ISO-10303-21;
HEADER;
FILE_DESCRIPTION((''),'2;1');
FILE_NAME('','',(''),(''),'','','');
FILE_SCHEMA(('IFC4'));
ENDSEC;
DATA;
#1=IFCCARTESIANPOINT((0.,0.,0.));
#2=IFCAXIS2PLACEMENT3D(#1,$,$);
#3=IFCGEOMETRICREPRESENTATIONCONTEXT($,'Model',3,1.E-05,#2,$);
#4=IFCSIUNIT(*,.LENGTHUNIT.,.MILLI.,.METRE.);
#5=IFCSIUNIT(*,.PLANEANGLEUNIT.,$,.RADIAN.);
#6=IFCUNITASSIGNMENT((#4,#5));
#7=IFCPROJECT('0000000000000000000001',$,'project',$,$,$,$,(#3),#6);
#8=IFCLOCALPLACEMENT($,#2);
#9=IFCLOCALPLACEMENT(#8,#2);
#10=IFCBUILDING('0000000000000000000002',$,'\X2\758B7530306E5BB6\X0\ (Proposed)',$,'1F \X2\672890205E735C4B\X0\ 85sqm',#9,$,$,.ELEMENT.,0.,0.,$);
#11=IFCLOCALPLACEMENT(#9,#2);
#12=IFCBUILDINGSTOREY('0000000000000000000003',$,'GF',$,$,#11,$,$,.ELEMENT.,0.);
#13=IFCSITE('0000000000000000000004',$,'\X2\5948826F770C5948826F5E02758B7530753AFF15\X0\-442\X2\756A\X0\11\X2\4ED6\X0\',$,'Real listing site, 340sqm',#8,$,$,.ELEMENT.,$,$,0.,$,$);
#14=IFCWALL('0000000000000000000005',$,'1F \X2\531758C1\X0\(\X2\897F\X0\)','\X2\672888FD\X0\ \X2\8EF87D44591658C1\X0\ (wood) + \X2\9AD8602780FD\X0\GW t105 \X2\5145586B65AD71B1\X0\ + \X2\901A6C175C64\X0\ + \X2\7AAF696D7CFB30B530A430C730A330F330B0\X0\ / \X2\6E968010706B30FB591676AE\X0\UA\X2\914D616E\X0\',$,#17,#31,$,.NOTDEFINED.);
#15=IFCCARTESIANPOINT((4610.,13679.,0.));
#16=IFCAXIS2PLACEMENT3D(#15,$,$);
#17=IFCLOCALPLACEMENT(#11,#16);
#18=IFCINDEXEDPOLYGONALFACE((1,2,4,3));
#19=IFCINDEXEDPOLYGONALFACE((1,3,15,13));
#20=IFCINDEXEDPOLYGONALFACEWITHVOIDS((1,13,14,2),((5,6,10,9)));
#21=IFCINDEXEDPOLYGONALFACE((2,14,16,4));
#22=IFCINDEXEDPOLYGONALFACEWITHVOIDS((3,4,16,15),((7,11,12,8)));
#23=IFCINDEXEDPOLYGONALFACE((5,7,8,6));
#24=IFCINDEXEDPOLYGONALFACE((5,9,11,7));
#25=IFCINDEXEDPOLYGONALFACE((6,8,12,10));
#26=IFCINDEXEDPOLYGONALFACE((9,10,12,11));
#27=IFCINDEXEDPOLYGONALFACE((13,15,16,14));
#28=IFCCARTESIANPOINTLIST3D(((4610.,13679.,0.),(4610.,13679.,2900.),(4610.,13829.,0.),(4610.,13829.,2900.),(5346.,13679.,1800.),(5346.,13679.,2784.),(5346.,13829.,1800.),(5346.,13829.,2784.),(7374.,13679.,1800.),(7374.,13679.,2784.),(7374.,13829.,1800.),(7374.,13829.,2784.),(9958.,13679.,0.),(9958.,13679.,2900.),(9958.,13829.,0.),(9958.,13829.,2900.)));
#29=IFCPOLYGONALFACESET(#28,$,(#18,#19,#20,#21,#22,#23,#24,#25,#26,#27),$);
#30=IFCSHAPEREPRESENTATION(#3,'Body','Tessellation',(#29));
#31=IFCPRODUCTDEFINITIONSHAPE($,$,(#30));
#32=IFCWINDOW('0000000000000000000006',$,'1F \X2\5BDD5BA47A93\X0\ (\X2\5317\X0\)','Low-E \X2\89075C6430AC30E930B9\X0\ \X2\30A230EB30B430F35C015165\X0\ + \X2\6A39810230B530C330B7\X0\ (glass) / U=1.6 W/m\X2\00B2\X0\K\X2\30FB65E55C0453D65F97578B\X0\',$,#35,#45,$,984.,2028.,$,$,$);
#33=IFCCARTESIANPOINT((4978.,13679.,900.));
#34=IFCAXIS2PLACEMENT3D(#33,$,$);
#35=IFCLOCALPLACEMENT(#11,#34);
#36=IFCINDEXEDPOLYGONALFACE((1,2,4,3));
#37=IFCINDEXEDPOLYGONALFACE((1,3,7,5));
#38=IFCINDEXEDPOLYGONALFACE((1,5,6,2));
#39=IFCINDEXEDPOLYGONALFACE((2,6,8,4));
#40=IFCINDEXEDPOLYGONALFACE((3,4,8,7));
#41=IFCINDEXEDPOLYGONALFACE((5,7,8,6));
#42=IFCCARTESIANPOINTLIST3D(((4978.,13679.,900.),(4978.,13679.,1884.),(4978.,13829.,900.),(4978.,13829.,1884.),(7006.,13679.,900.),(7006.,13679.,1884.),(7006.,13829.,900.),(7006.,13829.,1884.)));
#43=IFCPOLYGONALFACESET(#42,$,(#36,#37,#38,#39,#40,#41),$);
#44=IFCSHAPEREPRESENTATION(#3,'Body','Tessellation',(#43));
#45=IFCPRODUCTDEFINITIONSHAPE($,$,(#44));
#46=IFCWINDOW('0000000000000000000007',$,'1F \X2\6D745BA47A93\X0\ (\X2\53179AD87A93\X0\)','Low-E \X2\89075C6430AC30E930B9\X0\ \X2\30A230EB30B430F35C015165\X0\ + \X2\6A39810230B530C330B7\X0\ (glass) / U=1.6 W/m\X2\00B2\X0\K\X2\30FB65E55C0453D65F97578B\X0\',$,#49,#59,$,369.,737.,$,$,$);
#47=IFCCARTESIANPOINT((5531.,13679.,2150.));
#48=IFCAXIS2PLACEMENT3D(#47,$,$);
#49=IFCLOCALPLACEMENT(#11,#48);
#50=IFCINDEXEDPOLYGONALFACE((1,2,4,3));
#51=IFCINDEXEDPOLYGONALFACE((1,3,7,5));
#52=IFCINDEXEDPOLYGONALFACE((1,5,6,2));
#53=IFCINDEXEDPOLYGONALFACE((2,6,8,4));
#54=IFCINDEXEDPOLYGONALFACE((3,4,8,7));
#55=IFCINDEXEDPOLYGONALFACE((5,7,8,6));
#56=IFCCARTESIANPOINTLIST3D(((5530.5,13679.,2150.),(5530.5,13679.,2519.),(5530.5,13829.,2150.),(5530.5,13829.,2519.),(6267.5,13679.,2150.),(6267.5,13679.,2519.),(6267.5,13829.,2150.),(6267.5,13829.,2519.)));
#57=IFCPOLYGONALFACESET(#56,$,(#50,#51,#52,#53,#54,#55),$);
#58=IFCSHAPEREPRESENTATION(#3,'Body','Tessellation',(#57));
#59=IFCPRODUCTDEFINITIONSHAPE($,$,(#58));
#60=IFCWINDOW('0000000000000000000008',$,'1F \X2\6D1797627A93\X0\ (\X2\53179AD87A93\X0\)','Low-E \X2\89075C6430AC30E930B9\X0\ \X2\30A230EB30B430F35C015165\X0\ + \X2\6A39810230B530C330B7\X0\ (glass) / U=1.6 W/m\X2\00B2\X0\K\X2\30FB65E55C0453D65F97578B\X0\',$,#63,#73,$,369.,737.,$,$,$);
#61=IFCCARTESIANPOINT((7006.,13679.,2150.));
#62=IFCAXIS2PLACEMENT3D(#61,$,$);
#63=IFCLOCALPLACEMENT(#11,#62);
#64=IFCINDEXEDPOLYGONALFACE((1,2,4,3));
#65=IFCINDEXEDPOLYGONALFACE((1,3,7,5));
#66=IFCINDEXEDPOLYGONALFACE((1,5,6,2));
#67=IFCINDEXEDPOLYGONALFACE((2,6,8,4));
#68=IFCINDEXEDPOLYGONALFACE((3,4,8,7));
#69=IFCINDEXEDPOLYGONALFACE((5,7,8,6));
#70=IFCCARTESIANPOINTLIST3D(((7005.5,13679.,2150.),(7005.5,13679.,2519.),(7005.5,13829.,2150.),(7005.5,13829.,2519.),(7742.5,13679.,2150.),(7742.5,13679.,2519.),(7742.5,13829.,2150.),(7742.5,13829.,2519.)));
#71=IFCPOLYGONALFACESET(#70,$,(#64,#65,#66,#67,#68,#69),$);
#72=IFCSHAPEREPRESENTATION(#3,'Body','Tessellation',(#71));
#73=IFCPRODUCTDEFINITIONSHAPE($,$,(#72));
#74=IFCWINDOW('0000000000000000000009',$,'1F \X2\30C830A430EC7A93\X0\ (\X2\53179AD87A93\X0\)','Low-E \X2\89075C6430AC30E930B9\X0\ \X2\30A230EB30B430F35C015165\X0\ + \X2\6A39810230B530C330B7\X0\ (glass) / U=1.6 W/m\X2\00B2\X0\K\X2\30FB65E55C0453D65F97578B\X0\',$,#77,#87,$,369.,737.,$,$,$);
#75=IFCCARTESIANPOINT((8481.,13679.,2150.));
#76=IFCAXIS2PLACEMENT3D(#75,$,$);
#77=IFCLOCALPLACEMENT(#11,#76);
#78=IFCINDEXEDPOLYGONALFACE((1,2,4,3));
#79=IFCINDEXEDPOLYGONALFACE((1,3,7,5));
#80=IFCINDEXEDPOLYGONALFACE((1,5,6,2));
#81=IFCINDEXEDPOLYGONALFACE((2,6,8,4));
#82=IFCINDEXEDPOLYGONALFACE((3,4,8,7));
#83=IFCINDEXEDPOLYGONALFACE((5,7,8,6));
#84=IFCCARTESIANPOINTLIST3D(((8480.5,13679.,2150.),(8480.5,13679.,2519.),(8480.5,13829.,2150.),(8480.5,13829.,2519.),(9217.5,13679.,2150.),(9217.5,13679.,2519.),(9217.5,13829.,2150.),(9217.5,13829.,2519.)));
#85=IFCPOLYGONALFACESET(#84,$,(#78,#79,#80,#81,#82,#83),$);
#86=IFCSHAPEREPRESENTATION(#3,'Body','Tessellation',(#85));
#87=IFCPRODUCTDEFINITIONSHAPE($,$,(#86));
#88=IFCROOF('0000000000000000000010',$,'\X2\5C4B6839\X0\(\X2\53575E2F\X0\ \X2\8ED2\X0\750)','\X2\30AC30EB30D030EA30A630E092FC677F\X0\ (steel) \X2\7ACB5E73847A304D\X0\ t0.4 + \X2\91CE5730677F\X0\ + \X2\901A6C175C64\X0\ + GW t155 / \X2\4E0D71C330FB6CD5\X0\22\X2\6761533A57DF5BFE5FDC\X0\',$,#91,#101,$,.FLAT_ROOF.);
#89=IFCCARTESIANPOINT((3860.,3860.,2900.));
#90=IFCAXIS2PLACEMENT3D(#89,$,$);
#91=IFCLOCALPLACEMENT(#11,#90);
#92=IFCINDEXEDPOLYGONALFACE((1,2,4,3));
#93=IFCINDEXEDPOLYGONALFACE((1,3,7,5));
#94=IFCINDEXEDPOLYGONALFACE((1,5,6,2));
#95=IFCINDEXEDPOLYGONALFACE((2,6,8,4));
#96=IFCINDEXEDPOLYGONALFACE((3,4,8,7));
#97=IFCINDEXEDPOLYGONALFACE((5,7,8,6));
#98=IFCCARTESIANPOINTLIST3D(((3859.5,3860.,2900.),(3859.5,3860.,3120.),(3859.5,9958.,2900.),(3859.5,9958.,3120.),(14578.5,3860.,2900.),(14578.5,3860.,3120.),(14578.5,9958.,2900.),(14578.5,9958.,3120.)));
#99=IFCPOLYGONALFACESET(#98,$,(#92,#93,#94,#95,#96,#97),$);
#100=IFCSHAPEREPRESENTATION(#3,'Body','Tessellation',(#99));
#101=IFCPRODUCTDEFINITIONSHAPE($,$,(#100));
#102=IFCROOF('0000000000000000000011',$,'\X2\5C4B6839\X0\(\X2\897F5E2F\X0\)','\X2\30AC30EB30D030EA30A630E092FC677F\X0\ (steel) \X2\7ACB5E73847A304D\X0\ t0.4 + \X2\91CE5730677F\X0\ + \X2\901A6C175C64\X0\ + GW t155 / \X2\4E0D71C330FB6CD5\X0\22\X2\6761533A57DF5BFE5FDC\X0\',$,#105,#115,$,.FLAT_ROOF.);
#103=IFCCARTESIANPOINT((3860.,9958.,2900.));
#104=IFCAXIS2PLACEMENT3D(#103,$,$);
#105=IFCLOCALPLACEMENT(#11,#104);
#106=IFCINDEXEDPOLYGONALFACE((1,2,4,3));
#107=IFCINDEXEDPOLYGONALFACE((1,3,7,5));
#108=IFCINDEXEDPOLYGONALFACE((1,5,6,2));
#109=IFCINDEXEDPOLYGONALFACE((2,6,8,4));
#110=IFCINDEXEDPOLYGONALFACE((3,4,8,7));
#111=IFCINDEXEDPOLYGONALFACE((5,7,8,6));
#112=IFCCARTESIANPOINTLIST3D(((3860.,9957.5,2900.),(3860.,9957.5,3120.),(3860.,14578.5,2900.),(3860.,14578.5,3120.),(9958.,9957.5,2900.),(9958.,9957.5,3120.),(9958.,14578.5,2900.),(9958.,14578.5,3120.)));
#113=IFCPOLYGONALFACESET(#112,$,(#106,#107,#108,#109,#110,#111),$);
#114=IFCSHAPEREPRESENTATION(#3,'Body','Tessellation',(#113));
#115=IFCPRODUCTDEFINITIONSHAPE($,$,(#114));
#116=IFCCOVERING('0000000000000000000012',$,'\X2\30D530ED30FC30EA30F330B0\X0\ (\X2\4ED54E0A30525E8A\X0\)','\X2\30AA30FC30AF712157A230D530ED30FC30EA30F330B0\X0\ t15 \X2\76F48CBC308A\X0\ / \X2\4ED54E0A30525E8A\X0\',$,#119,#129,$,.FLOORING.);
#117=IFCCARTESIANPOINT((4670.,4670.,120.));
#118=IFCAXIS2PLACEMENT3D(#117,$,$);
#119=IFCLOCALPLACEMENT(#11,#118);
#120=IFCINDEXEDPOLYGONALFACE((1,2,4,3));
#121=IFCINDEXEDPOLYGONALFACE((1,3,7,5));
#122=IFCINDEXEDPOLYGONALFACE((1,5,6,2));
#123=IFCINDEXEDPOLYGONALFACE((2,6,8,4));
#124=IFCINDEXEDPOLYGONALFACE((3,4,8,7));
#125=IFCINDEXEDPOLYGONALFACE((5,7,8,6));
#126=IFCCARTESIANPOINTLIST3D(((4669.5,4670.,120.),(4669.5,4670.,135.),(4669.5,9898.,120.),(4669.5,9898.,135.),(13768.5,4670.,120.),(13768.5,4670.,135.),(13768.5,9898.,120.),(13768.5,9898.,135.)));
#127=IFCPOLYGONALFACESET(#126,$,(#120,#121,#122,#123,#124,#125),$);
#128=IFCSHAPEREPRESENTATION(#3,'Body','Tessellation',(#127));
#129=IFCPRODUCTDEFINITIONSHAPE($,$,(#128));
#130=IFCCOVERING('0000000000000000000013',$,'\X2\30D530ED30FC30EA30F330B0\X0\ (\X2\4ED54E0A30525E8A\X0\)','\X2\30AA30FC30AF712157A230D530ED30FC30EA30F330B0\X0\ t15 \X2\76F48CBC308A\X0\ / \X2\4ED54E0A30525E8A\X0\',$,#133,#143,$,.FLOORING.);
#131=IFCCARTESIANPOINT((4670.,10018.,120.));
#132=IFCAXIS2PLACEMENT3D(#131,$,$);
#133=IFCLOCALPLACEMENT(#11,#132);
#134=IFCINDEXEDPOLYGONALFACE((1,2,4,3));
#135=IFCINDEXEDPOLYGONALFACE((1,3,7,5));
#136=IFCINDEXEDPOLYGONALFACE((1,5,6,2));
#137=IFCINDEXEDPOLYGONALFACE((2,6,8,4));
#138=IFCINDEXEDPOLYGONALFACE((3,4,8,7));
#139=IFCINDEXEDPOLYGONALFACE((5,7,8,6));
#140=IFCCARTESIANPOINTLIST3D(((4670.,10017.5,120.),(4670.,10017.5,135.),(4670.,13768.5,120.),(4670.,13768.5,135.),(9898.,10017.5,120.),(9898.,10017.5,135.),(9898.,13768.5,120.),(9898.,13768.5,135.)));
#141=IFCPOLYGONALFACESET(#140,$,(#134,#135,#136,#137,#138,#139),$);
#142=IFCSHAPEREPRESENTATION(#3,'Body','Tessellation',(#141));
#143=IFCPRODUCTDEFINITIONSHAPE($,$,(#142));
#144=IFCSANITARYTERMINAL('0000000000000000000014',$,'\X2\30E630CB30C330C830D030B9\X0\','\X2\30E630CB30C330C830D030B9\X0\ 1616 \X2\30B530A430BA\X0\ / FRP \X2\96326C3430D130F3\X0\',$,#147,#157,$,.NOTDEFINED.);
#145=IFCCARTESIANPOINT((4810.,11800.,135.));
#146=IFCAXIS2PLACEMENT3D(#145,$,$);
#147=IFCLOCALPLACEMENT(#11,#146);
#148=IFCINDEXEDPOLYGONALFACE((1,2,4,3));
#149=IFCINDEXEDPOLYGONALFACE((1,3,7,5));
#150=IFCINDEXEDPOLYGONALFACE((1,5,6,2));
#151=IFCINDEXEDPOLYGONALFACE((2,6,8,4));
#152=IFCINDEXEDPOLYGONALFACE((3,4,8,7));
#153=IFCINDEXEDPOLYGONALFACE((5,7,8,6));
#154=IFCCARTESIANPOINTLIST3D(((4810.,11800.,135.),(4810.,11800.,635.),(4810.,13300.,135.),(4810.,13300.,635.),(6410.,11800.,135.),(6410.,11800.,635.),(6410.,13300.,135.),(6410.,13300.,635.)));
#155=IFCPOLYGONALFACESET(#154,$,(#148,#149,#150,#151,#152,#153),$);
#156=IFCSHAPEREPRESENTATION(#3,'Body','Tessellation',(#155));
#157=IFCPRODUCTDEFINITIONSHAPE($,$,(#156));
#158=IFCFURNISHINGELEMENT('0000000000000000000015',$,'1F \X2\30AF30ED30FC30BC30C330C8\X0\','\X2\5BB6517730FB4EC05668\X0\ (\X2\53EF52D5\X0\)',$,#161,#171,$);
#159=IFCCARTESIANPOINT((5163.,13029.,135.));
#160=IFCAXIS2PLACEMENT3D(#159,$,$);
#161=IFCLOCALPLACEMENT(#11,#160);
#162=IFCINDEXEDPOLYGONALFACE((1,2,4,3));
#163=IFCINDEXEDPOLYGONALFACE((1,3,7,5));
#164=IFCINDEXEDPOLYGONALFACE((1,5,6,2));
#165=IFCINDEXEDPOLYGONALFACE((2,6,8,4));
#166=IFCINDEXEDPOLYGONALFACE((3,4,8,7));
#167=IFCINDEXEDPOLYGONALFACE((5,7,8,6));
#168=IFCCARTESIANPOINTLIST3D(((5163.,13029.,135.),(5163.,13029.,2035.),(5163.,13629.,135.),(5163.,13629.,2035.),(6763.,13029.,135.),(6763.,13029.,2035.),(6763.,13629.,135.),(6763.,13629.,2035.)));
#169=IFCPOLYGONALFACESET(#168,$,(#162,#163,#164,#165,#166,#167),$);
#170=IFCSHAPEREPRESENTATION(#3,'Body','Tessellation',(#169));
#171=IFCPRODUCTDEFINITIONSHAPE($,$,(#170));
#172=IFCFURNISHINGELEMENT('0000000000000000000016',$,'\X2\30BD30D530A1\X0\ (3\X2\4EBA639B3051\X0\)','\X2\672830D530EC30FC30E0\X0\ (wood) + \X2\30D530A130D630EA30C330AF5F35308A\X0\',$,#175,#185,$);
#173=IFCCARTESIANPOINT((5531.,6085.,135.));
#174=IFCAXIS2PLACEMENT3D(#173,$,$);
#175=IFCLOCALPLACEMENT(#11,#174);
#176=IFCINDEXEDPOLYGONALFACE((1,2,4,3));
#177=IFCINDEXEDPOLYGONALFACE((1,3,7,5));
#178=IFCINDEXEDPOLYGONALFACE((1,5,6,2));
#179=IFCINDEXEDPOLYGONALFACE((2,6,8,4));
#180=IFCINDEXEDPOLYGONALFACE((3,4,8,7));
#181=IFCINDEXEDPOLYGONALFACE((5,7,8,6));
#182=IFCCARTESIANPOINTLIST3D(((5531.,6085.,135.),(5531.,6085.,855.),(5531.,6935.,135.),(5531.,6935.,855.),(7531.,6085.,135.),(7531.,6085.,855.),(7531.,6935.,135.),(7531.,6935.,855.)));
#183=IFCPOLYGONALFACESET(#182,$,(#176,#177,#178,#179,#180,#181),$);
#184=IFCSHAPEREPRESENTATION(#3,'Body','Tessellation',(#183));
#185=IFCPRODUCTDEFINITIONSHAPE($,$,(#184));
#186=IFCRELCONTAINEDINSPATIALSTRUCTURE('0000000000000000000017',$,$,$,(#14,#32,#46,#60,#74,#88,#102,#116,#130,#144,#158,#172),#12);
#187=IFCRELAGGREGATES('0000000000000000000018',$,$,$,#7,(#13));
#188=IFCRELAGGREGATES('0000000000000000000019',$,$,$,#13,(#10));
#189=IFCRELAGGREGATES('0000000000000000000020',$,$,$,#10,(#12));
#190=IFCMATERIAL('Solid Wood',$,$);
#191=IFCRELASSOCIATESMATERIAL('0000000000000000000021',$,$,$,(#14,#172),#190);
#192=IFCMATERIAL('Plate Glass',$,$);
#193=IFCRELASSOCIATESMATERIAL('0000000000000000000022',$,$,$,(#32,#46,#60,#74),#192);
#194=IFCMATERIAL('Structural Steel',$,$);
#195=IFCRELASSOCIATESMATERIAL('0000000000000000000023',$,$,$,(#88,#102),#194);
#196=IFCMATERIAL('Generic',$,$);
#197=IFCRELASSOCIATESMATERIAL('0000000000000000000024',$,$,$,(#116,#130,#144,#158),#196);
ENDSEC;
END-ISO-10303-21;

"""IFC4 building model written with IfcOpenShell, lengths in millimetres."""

from ifc_helpers import new_model, si_unit, frame, frame_2d, origin, place, context, project, spatial, rectangle, extrude, material, element, fill, save


model = new_model("IFC4")

# Units and contexts
model_context = context("Model", 3, precision=1e-05, world=origin())
ifc_project = project(units=[si_unit("LENGTHUNIT", "METRE", prefix="MILLI"), si_unit("PLANEANGLEUNIT", "RADIAN")], contexts=[model_context])

# Site, building, storey
site_placement = place(None, origin())
site = spatial("IfcSite", under=ifc_project, at=site_placement, Name="奈良県奈良市疋田町５-442番11他", ObjectType="Real listing site, 340sqm", CompositionType="ELEMENT", RefElevation=0.0)
building_placement = place(site_placement, origin())
building = spatial("IfcBuilding", under=site, at=building_placement, Name="疋田の家 (Proposed)", ObjectType="1F 木造平屋 85sqm", CompositionType="ELEMENT", ElevationOfRefHeight=0.0, ElevationOfTerrain=0.0)
storey_placement = place(building_placement, origin())
storey = spatial("IfcBuildingStorey", under=building, at=storey_placement, Name="GF", CompositionType="ELEMENT", Elevation=0.0)

# Shared definitions
ifc_material_1 = material(Name="Solid Wood")

# Shared definitions
ifc_material_2 = material(Name="Plate Glass")

# Wall, openings, windows
wall_1_placement = place(storey_placement, frame((4610.0, 13679.0, 0.0)))
wall_1 = element("IfcWall", 1, at=wall_1_placement, inside=storey, material=ifc_material_1, Name="1F 北壁(西)", Description="木製 軸組外壁 (wood) + 高性能GW t105 充填断熱 + 通気層 + 窯業系サイディング / 準耐火・外皮UA配慮", PredefinedType="NOTDEFINED", context=model_context, shape_type="SweptSolid", body=[
    extrude(rectangle(XDim=5348.0, YDim=150.0, at=frame_2d((2674.0, 75.0))), frame((4610.0, 13679.0, 0.0)), (0.0, 0.0, 1.0), 2900.0),
])
opening_1_placement = place(storey_placement, frame((4978.0, 13679.0, 900.0)))
opening_1 = element("IfcOpeningElement", 2, at=opening_1_placement, cuts=wall_1, PredefinedType="NOTDEFINED", context=model_context, shape_type="SweptSolid", body=[
    extrude(rectangle(XDim=2028.0, YDim=150.0, at=frame_2d((1014.0, 75.0))), frame((4978.0, 13679.0, 900.0)), (0.0, 0.0, 1.0), 984.0),
])
opening_2_placement = place(storey_placement, frame((5531.0, 13679.0, 2150.0)))
opening_2 = element("IfcOpeningElement", 3, at=opening_2_placement, cuts=wall_1, PredefinedType="NOTDEFINED", context=model_context, shape_type="SweptSolid", body=[
    extrude(rectangle(XDim=737.0, YDim=150.0, at=frame_2d((368.0, 75.0))), frame((5531.0, 13679.0, 2150.0)), (0.0, 0.0, 1.0), 369.0),
])
opening_3_placement = place(storey_placement, frame((7006.0, 13679.0, 2150.0)))
opening_3 = element("IfcOpeningElement", 4, at=opening_3_placement, cuts=wall_1, PredefinedType="NOTDEFINED", context=model_context, shape_type="SweptSolid", body=[
    extrude(rectangle(XDim=737.0, YDim=150.0, at=frame_2d((368.0, 75.0))), frame((7006.0, 13679.0, 2150.0)), (0.0, 0.0, 1.0), 369.0),
])
opening_4_placement = place(storey_placement, frame((8481.0, 13679.0, 2150.0)))
opening_4 = element("IfcOpeningElement", 5, at=opening_4_placement, cuts=wall_1, PredefinedType="NOTDEFINED", context=model_context, shape_type="SweptSolid", body=[
    extrude(rectangle(XDim=737.0, YDim=150.0, at=frame_2d((368.0, 75.0))), frame((8481.0, 13679.0, 2150.0)), (0.0, 0.0, 1.0), 369.0),
])
window_1_placement = place(storey_placement, frame((4978.0, 13679.0, 900.0)))
window_1 = element("IfcWindow", 6, at=window_1_placement, inside=storey, material=ifc_material_2, Name="1F 寝室窓 (北)", Description="Low-E 複層ガラス アルゴン封入 + 樹脂サッシ (glass) / U=1.6 W/m²K・日射取得型", OverallHeight=984.0, OverallWidth=2028.0, context=model_context, shape_type="SweptSolid", body=[
    extrude(rectangle(XDim=2028.0, YDim=150.0, at=frame_2d((1014.0, 75.0))), frame((4978.0, 13679.0, 900.0)), (0.0, 0.0, 1.0), 984.0),
])
fill(opening_1, window_1)
window_2_placement = place(storey_placement, frame((5531.0, 13679.0, 2150.0)))
window_2 = element("IfcWindow", 7, at=window_2_placement, inside=storey, material=ifc_material_2, Name="1F 浴室窓 (北高窓)", Description="Low-E 複層ガラス アルゴン封入 + 樹脂サッシ (glass) / U=1.6 W/m²K・日射取得型", OverallHeight=369.0, OverallWidth=737.0, context=model_context, shape_type="SweptSolid", body=[
    extrude(rectangle(XDim=737.0, YDim=150.0, at=frame_2d((368.0, 75.0))), frame((5531.0, 13679.0, 2150.0)), (0.0, 0.0, 1.0), 369.0),
])
fill(opening_2, window_2)
window_3_placement = place(storey_placement, frame((7006.0, 13679.0, 2150.0)))
window_3 = element("IfcWindow", 8, at=window_3_placement, inside=storey, material=ifc_material_2, Name="1F 洗面窓 (北高窓)", Description="Low-E 複層ガラス アルゴン封入 + 樹脂サッシ (glass) / U=1.6 W/m²K・日射取得型", OverallHeight=369.0, OverallWidth=737.0, context=model_context, shape_type="SweptSolid", body=[
    extrude(rectangle(XDim=737.0, YDim=150.0, at=frame_2d((368.0, 75.0))), frame((7006.0, 13679.0, 2150.0)), (0.0, 0.0, 1.0), 369.0),
])
fill(opening_3, window_3)
window_4_placement = place(storey_placement, frame((8481.0, 13679.0, 2150.0)))
window_4 = element("IfcWindow", 9, at=window_4_placement, inside=storey, material=ifc_material_2, Name="1F トイレ窓 (北高窓)", Description="Low-E 複層ガラス アルゴン封入 + 樹脂サッシ (glass) / U=1.6 W/m²K・日射取得型", OverallHeight=369.0, OverallWidth=737.0, context=model_context, shape_type="SweptSolid", body=[
    extrude(rectangle(XDim=737.0, YDim=150.0, at=frame_2d((368.0, 75.0))), frame((8481.0, 13679.0, 2150.0)), (0.0, 0.0, 1.0), 369.0),
])
fill(opening_4, window_4)

# Roofs
ifc_material_3 = material(Name="Structural Steel")
roof_1_placement = place(storey_placement, frame((3860.0, 3860.0, 2900.0)))
element("IfcRoof", 10, at=roof_1_placement, inside=storey, material=ifc_material_3, Name="屋根(南帯 軒750)", Description="ガルバリウム鋼板 (steel) 立平葺き t0.4 + 野地板 + 通気層 + GW t155 / 不燃・法22条区域対応", PredefinedType="FLAT_ROOF", context=model_context, shape_type="SweptSolid", body=[
    extrude(rectangle(XDim=10719.0, YDim=6098.0, at=frame_2d((5359.0, 3049.0))), frame((3860.0, 3860.0, 2900.0)), (0.0, 0.0, 1.0), 220.0),
])
roof_2_placement = place(storey_placement, frame((3860.0, 9958.0, 2900.0)))
element("IfcRoof", 11, at=roof_2_placement, inside=storey, material=ifc_material_3, Name="屋根(西帯)", Description="ガルバリウム鋼板 (steel) 立平葺き t0.4 + 野地板 + 通気層 + GW t155 / 不燃・法22条区域対応", PredefinedType="FLAT_ROOF", context=model_context, shape_type="SweptSolid", body=[
    extrude(rectangle(XDim=6098.0, YDim=4621.0, at=frame_2d((3049.0, 2310.0))), frame((3860.0, 9958.0, 2900.0)), (0.0, 0.0, 1.0), 220.0),
])

# Coverings
ifc_material_4 = material(Name="Generic")
covering_1_placement = place(storey_placement, frame((4670.0, 4670.0, 120.0)))
element("IfcCovering", 12, at=covering_1_placement, inside=storey, material=ifc_material_4, Name="フローリング (仕上げ床)", Description="オーク無垢フローリング t15 直貼り / 仕上げ床", PredefinedType="FLOORING", context=model_context, shape_type="SweptSolid", body=[
    extrude(rectangle(XDim=9099.0, YDim=5228.0, at=frame_2d((4549.0, 2614.0))), frame((4670.0, 4670.0, 120.0)), (0.0, 0.0, 1.0), 15.0),
])
covering_2_placement = place(storey_placement, frame((4670.0, 10018.0, 120.0)))
element("IfcCovering", 13, at=covering_2_placement, inside=storey, material=ifc_material_4, Name="フローリング (仕上げ床)", Description="オーク無垢フローリング t15 直貼り / 仕上げ床", PredefinedType="FLOORING", context=model_context, shape_type="SweptSolid", body=[
    extrude(rectangle(XDim=5228.0, YDim=3751.0, at=frame_2d((2614.0, 1875.0))), frame((4670.0, 10018.0, 120.0)), (0.0, 0.0, 1.0), 15.0),
])

# Sanitary terminal
sanitary_terminal_placement = place(storey_placement, frame((4810.0, 11800.0, 135.0)))
element("IfcSanitaryTerminal", 14, at=sanitary_terminal_placement, inside=storey, material=ifc_material_4, Name="ユニットバス", Description="ユニットバス 1616 サイズ / FRP 防水パン", PredefinedType="NOTDEFINED", context=model_context, shape_type="SweptSolid", body=[
    extrude(rectangle(XDim=1600.0, YDim=1500.0, at=frame_2d((800.0, 750.0))), frame((4810.0, 11800.0, 135.0)), (0.0, 0.0, 1.0), 500.0),
])

# Furnishing elements
furnishing_1_placement = place(storey_placement, frame((5163.0, 13029.0, 135.0)))
element("IfcFurnishingElement", 15, at=furnishing_1_placement, inside=storey, material=ifc_material_4, Name="1F クローゼット", Description="家具・什器 (可動)", context=model_context, shape_type="SweptSolid", body=[
    extrude(rectangle(XDim=1600.0, YDim=600.0, at=frame_2d((800.0, 300.0))), frame((5163.0, 13029.0, 135.0)), (0.0, 0.0, 1.0), 1900.0),
])
furnishing_2_placement = place(storey_placement, frame((5531.0, 6085.0, 135.0)))
element("IfcFurnishingElement", 16, at=furnishing_2_placement, inside=storey, material=ifc_material_1, Name="ソファ (3人掛け)", Description="木フレーム (wood) + ファブリック張り", context=model_context, shape_type="SweptSolid", body=[
    extrude(rectangle(XDim=2000.0, YDim=850.0, at=frame_2d((1000.0, 425.0))), frame((5531.0, 6085.0, 135.0)), (0.0, 0.0, 1.0), 720.0),
])

save(model, "model.ifc")
